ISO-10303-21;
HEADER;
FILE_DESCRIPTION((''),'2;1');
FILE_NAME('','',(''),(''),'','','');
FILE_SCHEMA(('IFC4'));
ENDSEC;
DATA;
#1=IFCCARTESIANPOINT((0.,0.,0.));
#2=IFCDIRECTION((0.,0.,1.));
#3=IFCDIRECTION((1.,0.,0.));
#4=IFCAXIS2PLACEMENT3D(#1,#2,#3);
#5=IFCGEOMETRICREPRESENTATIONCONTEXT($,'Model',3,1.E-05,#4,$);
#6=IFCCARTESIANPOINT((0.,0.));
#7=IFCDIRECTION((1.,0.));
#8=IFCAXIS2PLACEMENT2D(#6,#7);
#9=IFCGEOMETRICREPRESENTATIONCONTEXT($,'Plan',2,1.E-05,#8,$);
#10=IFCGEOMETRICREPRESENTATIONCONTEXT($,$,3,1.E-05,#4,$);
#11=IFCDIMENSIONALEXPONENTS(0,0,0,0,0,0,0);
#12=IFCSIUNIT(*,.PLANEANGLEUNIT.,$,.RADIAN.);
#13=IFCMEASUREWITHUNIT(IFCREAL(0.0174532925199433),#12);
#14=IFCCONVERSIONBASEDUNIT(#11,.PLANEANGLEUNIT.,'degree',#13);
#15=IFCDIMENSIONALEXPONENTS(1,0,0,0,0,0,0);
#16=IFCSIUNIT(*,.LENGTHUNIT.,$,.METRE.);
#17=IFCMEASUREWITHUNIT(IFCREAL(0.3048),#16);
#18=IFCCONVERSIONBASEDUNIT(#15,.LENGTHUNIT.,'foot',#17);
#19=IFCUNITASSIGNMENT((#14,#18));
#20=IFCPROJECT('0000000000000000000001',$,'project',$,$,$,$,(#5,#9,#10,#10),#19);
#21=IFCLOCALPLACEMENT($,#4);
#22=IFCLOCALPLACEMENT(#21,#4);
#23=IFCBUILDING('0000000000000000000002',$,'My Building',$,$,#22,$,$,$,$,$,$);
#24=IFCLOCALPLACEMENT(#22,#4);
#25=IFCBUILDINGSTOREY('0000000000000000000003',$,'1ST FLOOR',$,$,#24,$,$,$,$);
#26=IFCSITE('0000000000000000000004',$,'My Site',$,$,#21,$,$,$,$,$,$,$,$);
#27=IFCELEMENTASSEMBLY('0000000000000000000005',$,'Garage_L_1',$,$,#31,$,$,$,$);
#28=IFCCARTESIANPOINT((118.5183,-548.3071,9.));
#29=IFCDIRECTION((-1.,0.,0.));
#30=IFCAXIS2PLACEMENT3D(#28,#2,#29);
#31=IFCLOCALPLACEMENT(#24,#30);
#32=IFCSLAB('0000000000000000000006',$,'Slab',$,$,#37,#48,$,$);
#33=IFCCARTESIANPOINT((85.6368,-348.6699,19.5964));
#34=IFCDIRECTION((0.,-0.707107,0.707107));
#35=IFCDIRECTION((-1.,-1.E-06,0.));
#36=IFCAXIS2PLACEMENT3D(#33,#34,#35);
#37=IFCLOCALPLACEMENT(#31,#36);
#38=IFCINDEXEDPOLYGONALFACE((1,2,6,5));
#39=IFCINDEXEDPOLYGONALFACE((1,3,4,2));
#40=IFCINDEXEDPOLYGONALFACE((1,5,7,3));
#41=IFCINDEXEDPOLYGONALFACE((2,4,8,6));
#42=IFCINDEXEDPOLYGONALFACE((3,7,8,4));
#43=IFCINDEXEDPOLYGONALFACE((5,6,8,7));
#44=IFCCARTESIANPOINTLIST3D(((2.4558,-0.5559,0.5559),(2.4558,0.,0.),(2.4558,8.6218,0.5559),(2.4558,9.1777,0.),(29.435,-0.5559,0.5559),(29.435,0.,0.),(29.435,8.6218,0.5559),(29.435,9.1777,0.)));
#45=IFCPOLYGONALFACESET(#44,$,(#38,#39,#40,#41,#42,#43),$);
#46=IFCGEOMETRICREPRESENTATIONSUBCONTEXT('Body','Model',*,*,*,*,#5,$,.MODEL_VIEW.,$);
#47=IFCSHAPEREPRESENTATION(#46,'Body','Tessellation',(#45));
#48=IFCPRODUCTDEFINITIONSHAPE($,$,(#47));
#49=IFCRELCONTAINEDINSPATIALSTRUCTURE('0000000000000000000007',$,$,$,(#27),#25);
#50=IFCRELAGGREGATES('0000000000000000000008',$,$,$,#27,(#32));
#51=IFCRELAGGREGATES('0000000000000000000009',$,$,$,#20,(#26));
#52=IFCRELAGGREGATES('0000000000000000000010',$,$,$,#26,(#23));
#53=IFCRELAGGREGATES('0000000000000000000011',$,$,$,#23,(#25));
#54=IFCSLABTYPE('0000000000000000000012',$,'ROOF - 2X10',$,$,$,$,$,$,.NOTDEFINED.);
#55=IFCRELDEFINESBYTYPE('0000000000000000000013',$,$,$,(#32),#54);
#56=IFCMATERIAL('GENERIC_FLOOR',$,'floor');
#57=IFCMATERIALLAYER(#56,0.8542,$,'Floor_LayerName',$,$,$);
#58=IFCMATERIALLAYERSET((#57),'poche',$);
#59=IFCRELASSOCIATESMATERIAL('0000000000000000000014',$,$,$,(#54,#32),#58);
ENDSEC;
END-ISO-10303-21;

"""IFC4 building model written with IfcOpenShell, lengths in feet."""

from ifc_helpers import new_model, entity, si_unit, converted_unit, frame, origin_with_axes, origin_2d_with_axis, place, context, subcontext, project, spatial, line, indexed_curve, outline, extrude, material, layer, layer_set, layer_usage, type_object, element, aggregate, save


model = new_model("IFC4")

# Units and contexts
model_context = context("Model", 3, precision=1e-05, world=origin_with_axes())
plan_context = context("Plan", 2, precision=1e-05, world=origin_2d_with_axis())
context_of_model = context(None, 3, precision=1e-05, world=origin_with_axes())
body_context = subcontext(model_context, "Body", "Model", "MODEL_VIEW")
ifc_project = project(units=[converted_unit("PLANEANGLEUNIT", "degree", entity("IfcReal", 0.0174532925199433), si_unit("PLANEANGLEUNIT", "RADIAN"), dimensions=[0, 0, 0, 0, 0, 0, 0]), converted_unit("LENGTHUNIT", "foot", entity("IfcReal", 0.3048), si_unit("LENGTHUNIT", "METRE"), dimensions=[1, 0, 0, 0, 0, 0, 0])], contexts=[model_context, plan_context, context_of_model, context_of_model])

# Site, building, storey
site_placement = place(None, origin_with_axes())
site = spatial("IfcSite", under=ifc_project, at=site_placement, Name="My Site")
building_placement = place(site_placement, origin_with_axes())
building = spatial("IfcBuilding", under=site, at=building_placement, Name="My Building")
storey_placement = place(building_placement, origin_with_axes())
storey = spatial("IfcBuildingStorey", under=building, at=storey_placement, Name="1ST FLOOR")

# Element assembly, slab
assembly_1_placement = place(storey_placement, frame((118.5183, -548.3071, 9.0), z_axis=(0.0, 0.0, 1.0), x_axis=(-1.0, 0.0, 0.0)))
assembly_1 = element("IfcElementAssembly", 1, at=assembly_1_placement, inside=storey, Name="Garage_L_1")
ifc_material_1 = material(Name="GENERIC_FLOOR", Category="floor")
ifc_layer_1 = layer(ifc_material_1, 0.8542, Name="Floor_LayerName")
ifc_layer_set_1 = layer_set([ifc_layer_1], Name="poche")
ifc_layer_usage_1 = layer_usage(ifc_layer_set_1, "AXIS3", "POSITIVE", 0.0)
slab_type_1 = type_object("IfcSlabType", Name="ROOF - 2X10", PredefinedType="NOTDEFINED", material=ifc_layer_set_1)
slab_1_placement = place(assembly_1_placement, frame((85.6368, -348.6699, 19.5964), z_axis=(0.0, -0.707107, 0.707107), x_axis=(-1.0, -0.000001, 0.0)))
slab_1 = element("IfcSlab", 2, at=slab_1_placement, type_object=slab_type_1, material=ifc_layer_usage_1, Name="Slab", context=body_context, shape_type="SweptSolid", body=[
    extrude(outline(indexed_curve([(2.4558, 0.0), (2.4558, 9.1777), (29.435, 9.1777), (29.435, 0.0)], segments=[line(4, 1), line(1, 2), line(2, 3), line(3, 4)], self_intersect=False)), None, (0.0, -0.707107, 0.707107), 0.7861),
])

aggregate(assembly_1, [slab_1])

save(model, "model.ifc")
